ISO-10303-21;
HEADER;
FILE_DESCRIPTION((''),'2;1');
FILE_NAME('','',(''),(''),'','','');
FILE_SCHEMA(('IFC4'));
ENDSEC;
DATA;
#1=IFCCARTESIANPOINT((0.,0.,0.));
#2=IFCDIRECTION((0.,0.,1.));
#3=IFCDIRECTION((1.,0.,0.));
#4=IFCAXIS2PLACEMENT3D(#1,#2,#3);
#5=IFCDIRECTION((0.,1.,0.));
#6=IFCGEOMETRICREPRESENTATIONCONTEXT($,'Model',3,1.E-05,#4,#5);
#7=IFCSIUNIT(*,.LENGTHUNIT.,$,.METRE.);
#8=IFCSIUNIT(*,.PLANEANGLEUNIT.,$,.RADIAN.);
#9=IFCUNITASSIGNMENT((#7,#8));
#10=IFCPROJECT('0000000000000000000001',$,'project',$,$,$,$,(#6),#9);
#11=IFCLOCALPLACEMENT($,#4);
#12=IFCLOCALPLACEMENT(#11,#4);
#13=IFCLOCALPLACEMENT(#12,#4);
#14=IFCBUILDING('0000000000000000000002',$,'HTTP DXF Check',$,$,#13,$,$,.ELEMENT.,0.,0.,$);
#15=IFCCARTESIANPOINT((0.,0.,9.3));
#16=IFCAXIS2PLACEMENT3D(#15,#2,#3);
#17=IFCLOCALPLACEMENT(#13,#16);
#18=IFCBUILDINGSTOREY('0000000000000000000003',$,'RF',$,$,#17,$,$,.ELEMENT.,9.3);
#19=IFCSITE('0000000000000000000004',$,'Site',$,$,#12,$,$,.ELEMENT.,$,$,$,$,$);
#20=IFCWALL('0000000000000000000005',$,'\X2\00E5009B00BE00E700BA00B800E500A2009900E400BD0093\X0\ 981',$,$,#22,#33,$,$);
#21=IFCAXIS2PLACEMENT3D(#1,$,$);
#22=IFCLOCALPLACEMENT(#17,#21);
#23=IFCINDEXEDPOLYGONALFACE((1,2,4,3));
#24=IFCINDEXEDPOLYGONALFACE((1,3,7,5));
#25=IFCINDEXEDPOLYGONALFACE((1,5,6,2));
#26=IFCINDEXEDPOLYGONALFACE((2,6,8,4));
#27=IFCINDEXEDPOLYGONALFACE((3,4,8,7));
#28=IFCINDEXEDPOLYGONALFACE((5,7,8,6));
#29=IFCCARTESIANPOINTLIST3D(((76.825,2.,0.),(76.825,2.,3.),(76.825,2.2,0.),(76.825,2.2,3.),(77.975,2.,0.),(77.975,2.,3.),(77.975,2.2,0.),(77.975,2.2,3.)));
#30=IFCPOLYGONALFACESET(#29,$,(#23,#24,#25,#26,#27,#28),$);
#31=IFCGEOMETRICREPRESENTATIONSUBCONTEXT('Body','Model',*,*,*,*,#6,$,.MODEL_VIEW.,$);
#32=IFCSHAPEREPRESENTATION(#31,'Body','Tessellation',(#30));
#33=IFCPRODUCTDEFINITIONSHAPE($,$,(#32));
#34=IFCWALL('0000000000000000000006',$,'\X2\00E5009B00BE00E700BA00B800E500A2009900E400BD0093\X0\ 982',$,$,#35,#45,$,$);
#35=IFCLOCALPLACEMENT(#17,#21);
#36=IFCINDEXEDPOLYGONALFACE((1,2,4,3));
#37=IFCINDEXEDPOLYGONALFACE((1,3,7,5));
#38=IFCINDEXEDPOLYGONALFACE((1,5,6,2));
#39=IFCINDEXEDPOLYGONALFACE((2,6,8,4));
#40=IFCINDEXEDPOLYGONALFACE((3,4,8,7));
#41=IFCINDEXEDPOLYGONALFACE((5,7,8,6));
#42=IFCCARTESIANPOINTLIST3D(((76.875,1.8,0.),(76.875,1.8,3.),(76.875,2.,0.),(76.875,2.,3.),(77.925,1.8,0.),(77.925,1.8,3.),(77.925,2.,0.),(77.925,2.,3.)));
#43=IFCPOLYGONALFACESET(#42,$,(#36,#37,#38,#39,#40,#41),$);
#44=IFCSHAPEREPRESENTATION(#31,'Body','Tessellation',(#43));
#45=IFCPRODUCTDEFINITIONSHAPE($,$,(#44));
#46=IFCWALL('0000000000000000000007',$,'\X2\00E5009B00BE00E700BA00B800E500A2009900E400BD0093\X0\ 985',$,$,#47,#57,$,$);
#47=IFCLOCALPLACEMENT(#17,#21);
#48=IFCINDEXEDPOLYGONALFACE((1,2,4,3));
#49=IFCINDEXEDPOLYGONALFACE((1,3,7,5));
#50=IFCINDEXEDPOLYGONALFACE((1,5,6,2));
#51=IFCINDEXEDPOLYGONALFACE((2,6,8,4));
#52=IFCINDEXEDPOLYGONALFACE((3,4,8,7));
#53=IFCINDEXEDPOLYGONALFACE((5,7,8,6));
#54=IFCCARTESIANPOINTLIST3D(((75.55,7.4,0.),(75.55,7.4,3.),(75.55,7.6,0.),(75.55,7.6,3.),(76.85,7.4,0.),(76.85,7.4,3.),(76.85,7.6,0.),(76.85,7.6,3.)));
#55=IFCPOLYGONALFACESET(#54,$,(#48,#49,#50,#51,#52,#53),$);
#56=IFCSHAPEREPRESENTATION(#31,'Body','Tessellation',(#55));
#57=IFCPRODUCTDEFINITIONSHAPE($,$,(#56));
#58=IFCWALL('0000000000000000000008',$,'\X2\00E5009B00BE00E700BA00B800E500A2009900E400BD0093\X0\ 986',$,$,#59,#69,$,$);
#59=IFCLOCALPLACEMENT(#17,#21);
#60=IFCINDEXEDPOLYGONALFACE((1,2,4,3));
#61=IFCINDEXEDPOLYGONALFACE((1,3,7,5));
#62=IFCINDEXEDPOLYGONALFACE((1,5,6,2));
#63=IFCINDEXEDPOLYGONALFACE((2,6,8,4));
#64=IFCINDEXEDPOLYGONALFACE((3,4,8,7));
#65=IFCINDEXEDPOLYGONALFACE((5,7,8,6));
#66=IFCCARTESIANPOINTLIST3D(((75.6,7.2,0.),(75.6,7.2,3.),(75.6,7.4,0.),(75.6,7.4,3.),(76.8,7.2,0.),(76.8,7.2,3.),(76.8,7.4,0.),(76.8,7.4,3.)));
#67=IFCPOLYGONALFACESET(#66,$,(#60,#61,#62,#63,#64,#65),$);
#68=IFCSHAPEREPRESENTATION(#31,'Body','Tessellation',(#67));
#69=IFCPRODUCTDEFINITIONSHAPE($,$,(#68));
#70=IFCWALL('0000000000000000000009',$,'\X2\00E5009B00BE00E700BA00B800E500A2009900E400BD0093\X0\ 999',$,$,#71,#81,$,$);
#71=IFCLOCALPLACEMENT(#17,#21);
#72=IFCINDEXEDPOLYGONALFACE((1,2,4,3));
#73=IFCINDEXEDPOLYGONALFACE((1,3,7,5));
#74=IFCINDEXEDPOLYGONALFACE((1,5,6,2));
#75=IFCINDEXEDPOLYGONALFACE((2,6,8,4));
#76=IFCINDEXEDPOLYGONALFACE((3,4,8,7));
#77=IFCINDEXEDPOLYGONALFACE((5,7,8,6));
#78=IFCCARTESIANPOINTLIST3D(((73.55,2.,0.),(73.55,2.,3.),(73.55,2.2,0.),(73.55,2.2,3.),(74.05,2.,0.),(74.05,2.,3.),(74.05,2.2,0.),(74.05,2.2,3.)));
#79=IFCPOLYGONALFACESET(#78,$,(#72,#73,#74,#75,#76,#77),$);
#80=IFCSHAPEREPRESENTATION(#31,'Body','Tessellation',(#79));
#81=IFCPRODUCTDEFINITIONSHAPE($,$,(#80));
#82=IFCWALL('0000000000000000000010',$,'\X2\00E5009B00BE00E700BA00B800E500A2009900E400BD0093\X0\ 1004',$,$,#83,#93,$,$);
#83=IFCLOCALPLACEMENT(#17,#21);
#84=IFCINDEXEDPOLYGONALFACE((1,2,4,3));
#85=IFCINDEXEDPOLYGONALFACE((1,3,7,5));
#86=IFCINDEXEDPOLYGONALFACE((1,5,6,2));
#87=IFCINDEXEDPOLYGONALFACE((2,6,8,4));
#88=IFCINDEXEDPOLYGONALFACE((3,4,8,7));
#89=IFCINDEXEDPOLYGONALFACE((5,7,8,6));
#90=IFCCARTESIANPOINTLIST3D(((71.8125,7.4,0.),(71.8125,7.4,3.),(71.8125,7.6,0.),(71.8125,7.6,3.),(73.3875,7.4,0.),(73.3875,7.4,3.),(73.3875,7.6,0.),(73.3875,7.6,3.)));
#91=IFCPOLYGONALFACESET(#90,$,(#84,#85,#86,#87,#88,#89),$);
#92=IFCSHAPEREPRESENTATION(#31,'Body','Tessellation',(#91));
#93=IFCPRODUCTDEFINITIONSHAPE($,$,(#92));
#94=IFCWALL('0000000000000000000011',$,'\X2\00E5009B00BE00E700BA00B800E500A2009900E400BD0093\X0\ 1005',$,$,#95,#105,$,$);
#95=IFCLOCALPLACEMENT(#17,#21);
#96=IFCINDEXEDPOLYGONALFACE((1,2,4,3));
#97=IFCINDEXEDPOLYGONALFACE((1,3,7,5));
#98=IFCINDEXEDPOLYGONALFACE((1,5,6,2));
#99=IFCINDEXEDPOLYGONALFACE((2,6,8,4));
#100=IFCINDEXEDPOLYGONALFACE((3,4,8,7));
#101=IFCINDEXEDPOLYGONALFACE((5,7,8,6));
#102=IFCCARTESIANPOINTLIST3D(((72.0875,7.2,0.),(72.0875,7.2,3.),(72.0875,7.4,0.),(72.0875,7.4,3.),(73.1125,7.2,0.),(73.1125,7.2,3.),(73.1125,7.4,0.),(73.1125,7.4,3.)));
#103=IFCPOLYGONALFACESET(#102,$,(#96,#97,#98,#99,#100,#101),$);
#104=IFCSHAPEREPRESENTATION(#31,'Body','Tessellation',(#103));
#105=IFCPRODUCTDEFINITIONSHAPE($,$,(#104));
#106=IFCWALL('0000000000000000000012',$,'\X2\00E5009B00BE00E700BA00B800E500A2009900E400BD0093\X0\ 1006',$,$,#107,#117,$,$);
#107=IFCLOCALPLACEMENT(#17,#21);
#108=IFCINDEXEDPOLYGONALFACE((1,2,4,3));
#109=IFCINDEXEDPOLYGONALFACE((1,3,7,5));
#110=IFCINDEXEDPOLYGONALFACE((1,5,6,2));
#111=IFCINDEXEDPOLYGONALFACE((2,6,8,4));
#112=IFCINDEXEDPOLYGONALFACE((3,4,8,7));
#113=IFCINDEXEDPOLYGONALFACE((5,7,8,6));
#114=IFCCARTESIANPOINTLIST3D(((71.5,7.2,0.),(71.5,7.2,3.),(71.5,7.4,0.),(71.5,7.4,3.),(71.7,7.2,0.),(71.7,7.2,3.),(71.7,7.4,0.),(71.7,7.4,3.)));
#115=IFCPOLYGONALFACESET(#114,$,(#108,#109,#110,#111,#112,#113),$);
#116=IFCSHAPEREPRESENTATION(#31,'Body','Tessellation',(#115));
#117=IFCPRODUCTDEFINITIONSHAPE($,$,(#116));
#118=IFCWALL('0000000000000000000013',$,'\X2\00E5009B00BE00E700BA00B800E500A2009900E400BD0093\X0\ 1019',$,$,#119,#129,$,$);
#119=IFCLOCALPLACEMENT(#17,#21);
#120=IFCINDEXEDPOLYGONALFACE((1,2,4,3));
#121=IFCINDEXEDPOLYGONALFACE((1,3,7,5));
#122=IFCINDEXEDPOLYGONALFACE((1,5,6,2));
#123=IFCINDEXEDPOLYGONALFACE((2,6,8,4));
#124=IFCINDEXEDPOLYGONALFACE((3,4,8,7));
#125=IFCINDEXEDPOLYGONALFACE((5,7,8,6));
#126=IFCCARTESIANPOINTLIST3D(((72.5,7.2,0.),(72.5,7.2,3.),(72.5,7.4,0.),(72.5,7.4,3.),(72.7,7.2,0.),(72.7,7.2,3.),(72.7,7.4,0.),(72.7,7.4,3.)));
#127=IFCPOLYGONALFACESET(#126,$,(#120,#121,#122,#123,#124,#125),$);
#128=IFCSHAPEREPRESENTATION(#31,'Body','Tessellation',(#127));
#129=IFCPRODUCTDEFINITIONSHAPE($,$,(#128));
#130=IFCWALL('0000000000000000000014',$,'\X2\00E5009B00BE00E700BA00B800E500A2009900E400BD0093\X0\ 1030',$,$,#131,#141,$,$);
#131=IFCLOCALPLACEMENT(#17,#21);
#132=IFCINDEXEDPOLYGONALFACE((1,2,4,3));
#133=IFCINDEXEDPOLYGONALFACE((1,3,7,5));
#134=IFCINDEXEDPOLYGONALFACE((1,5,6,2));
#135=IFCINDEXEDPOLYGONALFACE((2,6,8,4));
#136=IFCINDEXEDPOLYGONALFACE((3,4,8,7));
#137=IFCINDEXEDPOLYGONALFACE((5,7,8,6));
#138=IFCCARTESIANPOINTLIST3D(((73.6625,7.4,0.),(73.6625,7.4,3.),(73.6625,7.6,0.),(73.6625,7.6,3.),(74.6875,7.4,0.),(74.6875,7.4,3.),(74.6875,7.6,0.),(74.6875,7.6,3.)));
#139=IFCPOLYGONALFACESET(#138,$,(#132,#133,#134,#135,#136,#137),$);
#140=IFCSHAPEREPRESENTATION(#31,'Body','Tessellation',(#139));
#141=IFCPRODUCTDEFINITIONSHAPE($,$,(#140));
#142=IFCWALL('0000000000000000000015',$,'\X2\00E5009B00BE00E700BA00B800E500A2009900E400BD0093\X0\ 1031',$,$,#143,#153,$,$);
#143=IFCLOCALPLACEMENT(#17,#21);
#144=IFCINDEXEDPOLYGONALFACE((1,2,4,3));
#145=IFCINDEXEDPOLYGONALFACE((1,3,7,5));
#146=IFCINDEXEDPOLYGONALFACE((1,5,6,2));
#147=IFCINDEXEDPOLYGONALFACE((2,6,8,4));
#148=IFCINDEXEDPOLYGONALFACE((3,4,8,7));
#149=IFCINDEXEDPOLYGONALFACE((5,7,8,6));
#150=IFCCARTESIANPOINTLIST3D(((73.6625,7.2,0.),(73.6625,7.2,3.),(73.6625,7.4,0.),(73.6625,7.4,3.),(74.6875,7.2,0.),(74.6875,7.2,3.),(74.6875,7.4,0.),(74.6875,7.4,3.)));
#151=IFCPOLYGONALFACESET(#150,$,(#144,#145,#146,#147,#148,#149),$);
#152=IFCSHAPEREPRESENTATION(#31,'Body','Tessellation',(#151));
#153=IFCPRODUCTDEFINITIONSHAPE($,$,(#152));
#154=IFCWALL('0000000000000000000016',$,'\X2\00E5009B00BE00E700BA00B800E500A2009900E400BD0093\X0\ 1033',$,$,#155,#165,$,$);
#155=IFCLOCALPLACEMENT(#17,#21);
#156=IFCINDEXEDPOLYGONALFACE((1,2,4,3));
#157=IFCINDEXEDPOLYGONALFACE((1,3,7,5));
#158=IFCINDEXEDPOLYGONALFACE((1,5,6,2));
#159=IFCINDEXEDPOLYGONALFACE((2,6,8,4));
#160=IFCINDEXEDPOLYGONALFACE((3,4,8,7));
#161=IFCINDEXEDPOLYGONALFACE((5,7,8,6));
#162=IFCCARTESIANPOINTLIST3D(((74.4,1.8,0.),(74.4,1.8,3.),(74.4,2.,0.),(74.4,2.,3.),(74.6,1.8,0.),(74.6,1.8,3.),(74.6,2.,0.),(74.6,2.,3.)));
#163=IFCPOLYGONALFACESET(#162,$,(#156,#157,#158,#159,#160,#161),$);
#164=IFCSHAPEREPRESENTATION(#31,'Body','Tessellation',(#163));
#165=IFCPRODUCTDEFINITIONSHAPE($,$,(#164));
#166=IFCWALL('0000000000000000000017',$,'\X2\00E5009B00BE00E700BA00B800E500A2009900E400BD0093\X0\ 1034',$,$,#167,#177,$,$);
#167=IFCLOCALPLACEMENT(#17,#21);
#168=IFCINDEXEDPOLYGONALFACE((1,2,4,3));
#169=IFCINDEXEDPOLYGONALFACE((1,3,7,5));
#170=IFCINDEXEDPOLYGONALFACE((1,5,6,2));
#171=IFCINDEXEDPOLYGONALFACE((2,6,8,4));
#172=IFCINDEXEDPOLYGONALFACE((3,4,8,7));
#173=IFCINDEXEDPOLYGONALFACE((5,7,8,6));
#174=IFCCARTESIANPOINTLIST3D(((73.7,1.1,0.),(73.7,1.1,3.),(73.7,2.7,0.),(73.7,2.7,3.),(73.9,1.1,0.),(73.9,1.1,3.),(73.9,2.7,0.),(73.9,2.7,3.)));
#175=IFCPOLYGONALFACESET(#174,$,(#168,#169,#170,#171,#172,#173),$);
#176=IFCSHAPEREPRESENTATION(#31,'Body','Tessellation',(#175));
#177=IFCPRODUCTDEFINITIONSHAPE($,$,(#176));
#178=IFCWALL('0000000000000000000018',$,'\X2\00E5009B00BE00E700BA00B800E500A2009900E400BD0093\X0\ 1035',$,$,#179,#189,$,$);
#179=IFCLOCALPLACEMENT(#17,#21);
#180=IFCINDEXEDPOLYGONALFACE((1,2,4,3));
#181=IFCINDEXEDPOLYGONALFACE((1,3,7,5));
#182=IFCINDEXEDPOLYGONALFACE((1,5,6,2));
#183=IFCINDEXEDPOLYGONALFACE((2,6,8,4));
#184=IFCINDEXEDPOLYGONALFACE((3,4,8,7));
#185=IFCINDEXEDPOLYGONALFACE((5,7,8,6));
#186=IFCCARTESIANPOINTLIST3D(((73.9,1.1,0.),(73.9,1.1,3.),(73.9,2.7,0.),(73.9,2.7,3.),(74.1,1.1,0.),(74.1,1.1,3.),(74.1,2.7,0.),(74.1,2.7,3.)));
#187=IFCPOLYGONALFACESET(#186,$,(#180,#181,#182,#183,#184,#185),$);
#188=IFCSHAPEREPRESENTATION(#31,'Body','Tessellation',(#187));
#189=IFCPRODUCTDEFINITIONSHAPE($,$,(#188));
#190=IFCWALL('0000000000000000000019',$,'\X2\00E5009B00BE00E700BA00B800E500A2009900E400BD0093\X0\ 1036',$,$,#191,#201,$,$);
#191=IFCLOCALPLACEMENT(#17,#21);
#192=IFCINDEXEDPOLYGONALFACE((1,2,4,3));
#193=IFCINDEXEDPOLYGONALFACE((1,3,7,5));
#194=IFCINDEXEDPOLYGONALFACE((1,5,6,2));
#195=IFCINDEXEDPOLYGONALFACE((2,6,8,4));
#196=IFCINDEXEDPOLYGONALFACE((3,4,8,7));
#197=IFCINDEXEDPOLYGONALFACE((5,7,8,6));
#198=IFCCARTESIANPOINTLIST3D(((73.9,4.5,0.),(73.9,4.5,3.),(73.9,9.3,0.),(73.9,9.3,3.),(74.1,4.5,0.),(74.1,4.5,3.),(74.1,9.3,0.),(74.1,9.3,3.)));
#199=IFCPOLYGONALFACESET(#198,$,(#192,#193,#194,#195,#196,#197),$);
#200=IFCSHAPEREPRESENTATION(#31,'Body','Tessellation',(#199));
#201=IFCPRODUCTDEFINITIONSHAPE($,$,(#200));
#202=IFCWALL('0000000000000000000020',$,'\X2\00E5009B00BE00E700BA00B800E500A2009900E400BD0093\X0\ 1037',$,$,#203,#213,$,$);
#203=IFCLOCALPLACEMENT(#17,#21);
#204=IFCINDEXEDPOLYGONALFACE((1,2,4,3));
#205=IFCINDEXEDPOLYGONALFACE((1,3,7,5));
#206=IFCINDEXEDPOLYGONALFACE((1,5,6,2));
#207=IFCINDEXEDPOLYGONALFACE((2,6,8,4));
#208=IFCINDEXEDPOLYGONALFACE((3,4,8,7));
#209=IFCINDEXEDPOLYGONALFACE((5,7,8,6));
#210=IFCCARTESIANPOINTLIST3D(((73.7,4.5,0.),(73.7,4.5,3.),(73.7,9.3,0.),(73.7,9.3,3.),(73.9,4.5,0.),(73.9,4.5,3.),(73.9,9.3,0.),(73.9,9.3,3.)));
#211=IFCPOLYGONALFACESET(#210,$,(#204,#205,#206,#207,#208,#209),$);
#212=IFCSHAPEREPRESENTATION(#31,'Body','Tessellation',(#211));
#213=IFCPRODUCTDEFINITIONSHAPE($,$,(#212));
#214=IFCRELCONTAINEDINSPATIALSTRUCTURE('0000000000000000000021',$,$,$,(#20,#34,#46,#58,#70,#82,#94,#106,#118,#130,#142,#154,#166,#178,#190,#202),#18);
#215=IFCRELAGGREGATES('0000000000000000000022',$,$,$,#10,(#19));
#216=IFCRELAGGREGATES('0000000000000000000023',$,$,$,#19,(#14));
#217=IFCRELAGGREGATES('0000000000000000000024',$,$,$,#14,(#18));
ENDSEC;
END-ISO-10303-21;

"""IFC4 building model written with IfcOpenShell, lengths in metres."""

from ifc_helpers import new_model, si_unit, direction, frame, frame_2d, origin_with_axes, place, context, subcontext, project, spatial, rectangle, extrude, element, save


model = new_model("IFC4")

# Units and contexts
model_context = context("Model", 3, precision=1e-05, world=origin_with_axes(), true_north=direction((0.0, 1.0, 0.0)))
body_context = subcontext(model_context, "Body", "Model", "MODEL_VIEW")
ifc_project = project(units=[si_unit("LENGTHUNIT", "METRE"), si_unit("PLANEANGLEUNIT", "RADIAN")], contexts=[model_context])

# Site, building, storey
placement = place(None, origin_with_axes())
site_placement = place(placement, origin_with_axes())
site = spatial("IfcSite", under=ifc_project, at=site_placement, Name="Site", CompositionType="ELEMENT")
building_placement = place(site_placement, origin_with_axes())
building = spatial("IfcBuilding", under=site, at=building_placement, Name="HTTP DXF Check", CompositionType="ELEMENT", ElevationOfRefHeight=0.0, ElevationOfTerrain=0.0)
storey_placement = place(building_placement, frame((0.0, 0.0, 9.3), z_axis=(0.0, 0.0, 1.0), x_axis=(1.0, 0.0, 0.0)))
storey = spatial("IfcBuildingStorey", under=building, at=storey_placement, Name="RF", CompositionType="ELEMENT", Elevation=9.3)

# Walls
wall_1_placement = place(storey_placement, frame((77.4, 2.1, 0.0), z_axis=(0.0, 0.0, 1.0), x_axis=(-1.0, 0.0, 0.0)))
element("IfcWall", 1, at=wall_1_placement, inside=storey, Name="å\u009b¾çº¸å¢\u0099ä½\u0093 981", context=body_context, shape_type="SweptSolid", body=[
    extrude(rectangle(XDim=1.15, YDim=0.2, at=frame_2d((0.0, 0.0), x_axis=(1.0, 0.0, 0.0))), frame((0.0, 0.0, 0.0), z_axis=(0.0, 0.0, 1.0)), (0.0, 0.0, 1.0), 3.0),
])
wall_2_placement = place(storey_placement, frame((77.4, 1.9, 0.0), z_axis=(0.0, 0.0, 1.0), x_axis=(-1.0, 0.0, 0.0)))
element("IfcWall", 2, at=wall_2_placement, inside=storey, Name="å\u009b¾çº¸å¢\u0099ä½\u0093 982", context=body_context, shape_type="SweptSolid", body=[
    extrude(rectangle(XDim=1.05, YDim=0.2, at=frame_2d((0.0, 0.0), x_axis=(1.0, 0.0, 0.0))), frame((0.0, 0.0, 0.0), z_axis=(0.0, 0.0, 1.0)), (0.0, 0.0, 1.0), 3.0),
])
wall_3_placement = place(storey_placement, frame((76.2, 7.5, 0.0), z_axis=(0.0, 0.0, 1.0), x_axis=(1.0, 0.0, 0.0)))
element("IfcWall", 3, at=wall_3_placement, inside=storey, Name="å\u009b¾çº¸å¢\u0099ä½\u0093 985", context=body_context, shape_type="SweptSolid", body=[
    extrude(rectangle(XDim=1.3, YDim=0.2, at=frame_2d((0.0, 0.0), x_axis=(1.0, 0.0, 0.0))), frame((0.0, 0.0, 0.0), z_axis=(0.0, 0.0, 1.0)), (0.0, 0.0, 1.0), 3.0),
])
wall_4_placement = place(storey_placement, frame((76.2, 7.3, 0.0), z_axis=(0.0, 0.0, 1.0), x_axis=(1.0, 0.0, 0.0)))
element("IfcWall", 4, at=wall_4_placement, inside=storey, Name="å\u009b¾çº¸å¢\u0099ä½\u0093 986", context=body_context, shape_type="SweptSolid", body=[
    extrude(rectangle(XDim=1.2, YDim=0.2, at=frame_2d((0.0, 0.0), x_axis=(1.0, 0.0, 0.0))), frame((0.0, 0.0, 0.0), z_axis=(0.0, 0.0, 1.0)), (0.0, 0.0, 1.0), 3.0),
])
wall_5_placement = place(storey_placement, frame((73.8, 2.1, 0.0), z_axis=(0.0, 0.0, 1.0), x_axis=(-1.0, 0.0, 0.0)))
element("IfcWall", 5, at=wall_5_placement, inside=storey, Name="å\u009b¾çº¸å¢\u0099ä½\u0093 999", context=body_context, shape_type="SweptSolid", body=[
    extrude(rectangle(XDim=0.5, YDim=0.2, at=frame_2d((0.0, 0.0), x_axis=(1.0, 0.0, 0.0))), frame((0.0, 0.0, 0.0), z_axis=(0.0, 0.0, 1.0)), (0.0, 0.0, 1.0), 3.0),
])
wall_6_placement = place(storey_placement, frame((72.6, 7.5, 0.0), z_axis=(0.0, 0.0, 1.0), x_axis=(1.0, 0.0, 0.0)))
element("IfcWall", 6, at=wall_6_placement, inside=storey, Name="å\u009b¾çº¸å¢\u0099ä½\u0093 1004", context=body_context, shape_type="SweptSolid", body=[
    extrude(rectangle(XDim=1.575, YDim=0.2, at=frame_2d((0.0, 0.0), x_axis=(1.0, 0.0, 0.0))), frame((0.0, 0.0, 0.0), z_axis=(0.0, 0.0, 1.0)), (0.0, 0.0, 1.0), 3.0),
])
wall_7_placement = place(storey_placement, frame((72.6, 7.3, 0.0), z_axis=(0.0, 0.0, 1.0), x_axis=(1.0, 0.0, 0.0)))
element("IfcWall", 7, at=wall_7_placement, inside=storey, Name="å\u009b¾çº¸å¢\u0099ä½\u0093 1005", context=body_context, shape_type="SweptSolid", body=[
    extrude(rectangle(XDim=1.025, YDim=0.2, at=frame_2d((0.0, 0.0), x_axis=(1.0, 0.0, 0.0))), frame((0.0, 0.0, 0.0), z_axis=(0.0, 0.0, 1.0)), (0.0, 0.0, 1.0), 3.0),
])
for number, where, z_axis, x_axis, name in (
    (8, (71.6, 7.3, 0.0), (0.0, 0.0, 1.0), (0.0, 1.0, 0.0), "å\u009b¾çº¸å¢\u0099ä½\u0093 1006"),
    (9, (72.6, 7.3, 0.0), (0.0, 0.0, 1.0), (0.0, 1.0, 0.0), "å\u009b¾çº¸å¢\u0099ä½\u0093 1019"),
):
    element("IfcWall", number, at=place(storey_placement, frame(where, z_axis=z_axis, x_axis=x_axis)), inside=storey, Name=name, context=body_context, shape_type="SweptSolid", body=[
        extrude(rectangle(XDim=0.2, YDim=0.2, at=frame_2d((0.0, 0.0), x_axis=(1.0, 0.0, 0.0))), frame((0.0, 0.0, 0.0), z_axis=(0.0, 0.0, 1.0)), (0.0, 0.0, 1.0), 3.0),
    ])
for number, where, z_axis, x_axis, name in (
    (10, (74.175, 7.5, 0.0), (0.0, 0.0, 1.0), (1.0, 0.0, 0.0), "å\u009b¾çº¸å¢\u0099ä½\u0093 1030"),
    (11, (74.175, 7.3, 0.0), (0.0, 0.0, 1.0), (1.0, 0.0, 0.0), "å\u009b¾çº¸å¢\u0099ä½\u0093 1031"),
):
    element("IfcWall", number, at=place(storey_placement, frame(where, z_axis=z_axis, x_axis=x_axis)), inside=storey, Name=name, context=body_context, shape_type="SweptSolid", body=[
        extrude(rectangle(XDim=1.025, YDim=0.2, at=frame_2d((0.0, 0.0), x_axis=(1.0, 0.0, 0.0))), frame((0.0, 0.0, 0.0), z_axis=(0.0, 0.0, 1.0)), (0.0, 0.0, 1.0), 3.0),
    ])
wall_8_placement = place(storey_placement, frame((74.5, 1.9, 0.0), z_axis=(0.0, 0.0, 1.0), x_axis=(0.0, 1.0, 0.0)))
element("IfcWall", 12, at=wall_8_placement, inside=storey, Name="å\u009b¾çº¸å¢\u0099ä½\u0093 1033", context=body_context, shape_type="SweptSolid", body=[
    extrude(rectangle(XDim=0.2, YDim=0.2, at=frame_2d((0.0, 0.0), x_axis=(1.0, 0.0, 0.0))), frame((0.0, 0.0, 0.0), z_axis=(0.0, 0.0, 1.0)), (0.0, 0.0, 1.0), 3.0),
])
for number, where, z_axis, x_axis, name in (
    (13, (73.8, 1.9, 0.0), (0.0, 0.0, 1.0), (0.0, -1.0, 0.0), "å\u009b¾çº¸å¢\u0099ä½\u0093 1034"),
    (14, (74.0, 1.9, 0.0), (0.0, 0.0, 1.0), (0.0, -1.0, 0.0), "å\u009b¾çº¸å¢\u0099ä½\u0093 1035"),
):
    element("IfcWall", number, at=place(storey_placement, frame(where, z_axis=z_axis, x_axis=x_axis)), inside=storey, Name=name, context=body_context, shape_type="SweptSolid", body=[
        extrude(rectangle(XDim=1.6, YDim=0.2, at=frame_2d((0.0, 0.0), x_axis=(1.0, 0.0, 0.0))), frame((0.0, 0.0, 0.0), z_axis=(0.0, 0.0, 1.0)), (0.0, 0.0, 1.0), 3.0),
    ])
for number, where, z_axis, x_axis, name in (
    (15, (74.0, 6.9, 0.0), (0.0, 0.0, 1.0), (0.0, -1.0, 0.0), "å\u009b¾çº¸å¢\u0099ä½\u0093 1036"),
    (16, (73.8, 6.9, 0.0), (0.0, 0.0, 1.0), (0.0, -1.0, 0.0), "å\u009b¾çº¸å¢\u0099ä½\u0093 1037"),
):
    element("IfcWall", number, at=place(storey_placement, frame(where, z_axis=z_axis, x_axis=x_axis)), inside=storey, Name=name, context=body_context, shape_type="SweptSolid", body=[
        extrude(rectangle(XDim=4.8, YDim=0.2, at=frame_2d((0.0, 0.0), x_axis=(1.0, 0.0, 0.0))), frame((0.0, 0.0, 0.0), z_axis=(0.0, 0.0, 1.0)), (0.0, 0.0, 1.0), 3.0),
    ])

save(model, "model.ifc")
